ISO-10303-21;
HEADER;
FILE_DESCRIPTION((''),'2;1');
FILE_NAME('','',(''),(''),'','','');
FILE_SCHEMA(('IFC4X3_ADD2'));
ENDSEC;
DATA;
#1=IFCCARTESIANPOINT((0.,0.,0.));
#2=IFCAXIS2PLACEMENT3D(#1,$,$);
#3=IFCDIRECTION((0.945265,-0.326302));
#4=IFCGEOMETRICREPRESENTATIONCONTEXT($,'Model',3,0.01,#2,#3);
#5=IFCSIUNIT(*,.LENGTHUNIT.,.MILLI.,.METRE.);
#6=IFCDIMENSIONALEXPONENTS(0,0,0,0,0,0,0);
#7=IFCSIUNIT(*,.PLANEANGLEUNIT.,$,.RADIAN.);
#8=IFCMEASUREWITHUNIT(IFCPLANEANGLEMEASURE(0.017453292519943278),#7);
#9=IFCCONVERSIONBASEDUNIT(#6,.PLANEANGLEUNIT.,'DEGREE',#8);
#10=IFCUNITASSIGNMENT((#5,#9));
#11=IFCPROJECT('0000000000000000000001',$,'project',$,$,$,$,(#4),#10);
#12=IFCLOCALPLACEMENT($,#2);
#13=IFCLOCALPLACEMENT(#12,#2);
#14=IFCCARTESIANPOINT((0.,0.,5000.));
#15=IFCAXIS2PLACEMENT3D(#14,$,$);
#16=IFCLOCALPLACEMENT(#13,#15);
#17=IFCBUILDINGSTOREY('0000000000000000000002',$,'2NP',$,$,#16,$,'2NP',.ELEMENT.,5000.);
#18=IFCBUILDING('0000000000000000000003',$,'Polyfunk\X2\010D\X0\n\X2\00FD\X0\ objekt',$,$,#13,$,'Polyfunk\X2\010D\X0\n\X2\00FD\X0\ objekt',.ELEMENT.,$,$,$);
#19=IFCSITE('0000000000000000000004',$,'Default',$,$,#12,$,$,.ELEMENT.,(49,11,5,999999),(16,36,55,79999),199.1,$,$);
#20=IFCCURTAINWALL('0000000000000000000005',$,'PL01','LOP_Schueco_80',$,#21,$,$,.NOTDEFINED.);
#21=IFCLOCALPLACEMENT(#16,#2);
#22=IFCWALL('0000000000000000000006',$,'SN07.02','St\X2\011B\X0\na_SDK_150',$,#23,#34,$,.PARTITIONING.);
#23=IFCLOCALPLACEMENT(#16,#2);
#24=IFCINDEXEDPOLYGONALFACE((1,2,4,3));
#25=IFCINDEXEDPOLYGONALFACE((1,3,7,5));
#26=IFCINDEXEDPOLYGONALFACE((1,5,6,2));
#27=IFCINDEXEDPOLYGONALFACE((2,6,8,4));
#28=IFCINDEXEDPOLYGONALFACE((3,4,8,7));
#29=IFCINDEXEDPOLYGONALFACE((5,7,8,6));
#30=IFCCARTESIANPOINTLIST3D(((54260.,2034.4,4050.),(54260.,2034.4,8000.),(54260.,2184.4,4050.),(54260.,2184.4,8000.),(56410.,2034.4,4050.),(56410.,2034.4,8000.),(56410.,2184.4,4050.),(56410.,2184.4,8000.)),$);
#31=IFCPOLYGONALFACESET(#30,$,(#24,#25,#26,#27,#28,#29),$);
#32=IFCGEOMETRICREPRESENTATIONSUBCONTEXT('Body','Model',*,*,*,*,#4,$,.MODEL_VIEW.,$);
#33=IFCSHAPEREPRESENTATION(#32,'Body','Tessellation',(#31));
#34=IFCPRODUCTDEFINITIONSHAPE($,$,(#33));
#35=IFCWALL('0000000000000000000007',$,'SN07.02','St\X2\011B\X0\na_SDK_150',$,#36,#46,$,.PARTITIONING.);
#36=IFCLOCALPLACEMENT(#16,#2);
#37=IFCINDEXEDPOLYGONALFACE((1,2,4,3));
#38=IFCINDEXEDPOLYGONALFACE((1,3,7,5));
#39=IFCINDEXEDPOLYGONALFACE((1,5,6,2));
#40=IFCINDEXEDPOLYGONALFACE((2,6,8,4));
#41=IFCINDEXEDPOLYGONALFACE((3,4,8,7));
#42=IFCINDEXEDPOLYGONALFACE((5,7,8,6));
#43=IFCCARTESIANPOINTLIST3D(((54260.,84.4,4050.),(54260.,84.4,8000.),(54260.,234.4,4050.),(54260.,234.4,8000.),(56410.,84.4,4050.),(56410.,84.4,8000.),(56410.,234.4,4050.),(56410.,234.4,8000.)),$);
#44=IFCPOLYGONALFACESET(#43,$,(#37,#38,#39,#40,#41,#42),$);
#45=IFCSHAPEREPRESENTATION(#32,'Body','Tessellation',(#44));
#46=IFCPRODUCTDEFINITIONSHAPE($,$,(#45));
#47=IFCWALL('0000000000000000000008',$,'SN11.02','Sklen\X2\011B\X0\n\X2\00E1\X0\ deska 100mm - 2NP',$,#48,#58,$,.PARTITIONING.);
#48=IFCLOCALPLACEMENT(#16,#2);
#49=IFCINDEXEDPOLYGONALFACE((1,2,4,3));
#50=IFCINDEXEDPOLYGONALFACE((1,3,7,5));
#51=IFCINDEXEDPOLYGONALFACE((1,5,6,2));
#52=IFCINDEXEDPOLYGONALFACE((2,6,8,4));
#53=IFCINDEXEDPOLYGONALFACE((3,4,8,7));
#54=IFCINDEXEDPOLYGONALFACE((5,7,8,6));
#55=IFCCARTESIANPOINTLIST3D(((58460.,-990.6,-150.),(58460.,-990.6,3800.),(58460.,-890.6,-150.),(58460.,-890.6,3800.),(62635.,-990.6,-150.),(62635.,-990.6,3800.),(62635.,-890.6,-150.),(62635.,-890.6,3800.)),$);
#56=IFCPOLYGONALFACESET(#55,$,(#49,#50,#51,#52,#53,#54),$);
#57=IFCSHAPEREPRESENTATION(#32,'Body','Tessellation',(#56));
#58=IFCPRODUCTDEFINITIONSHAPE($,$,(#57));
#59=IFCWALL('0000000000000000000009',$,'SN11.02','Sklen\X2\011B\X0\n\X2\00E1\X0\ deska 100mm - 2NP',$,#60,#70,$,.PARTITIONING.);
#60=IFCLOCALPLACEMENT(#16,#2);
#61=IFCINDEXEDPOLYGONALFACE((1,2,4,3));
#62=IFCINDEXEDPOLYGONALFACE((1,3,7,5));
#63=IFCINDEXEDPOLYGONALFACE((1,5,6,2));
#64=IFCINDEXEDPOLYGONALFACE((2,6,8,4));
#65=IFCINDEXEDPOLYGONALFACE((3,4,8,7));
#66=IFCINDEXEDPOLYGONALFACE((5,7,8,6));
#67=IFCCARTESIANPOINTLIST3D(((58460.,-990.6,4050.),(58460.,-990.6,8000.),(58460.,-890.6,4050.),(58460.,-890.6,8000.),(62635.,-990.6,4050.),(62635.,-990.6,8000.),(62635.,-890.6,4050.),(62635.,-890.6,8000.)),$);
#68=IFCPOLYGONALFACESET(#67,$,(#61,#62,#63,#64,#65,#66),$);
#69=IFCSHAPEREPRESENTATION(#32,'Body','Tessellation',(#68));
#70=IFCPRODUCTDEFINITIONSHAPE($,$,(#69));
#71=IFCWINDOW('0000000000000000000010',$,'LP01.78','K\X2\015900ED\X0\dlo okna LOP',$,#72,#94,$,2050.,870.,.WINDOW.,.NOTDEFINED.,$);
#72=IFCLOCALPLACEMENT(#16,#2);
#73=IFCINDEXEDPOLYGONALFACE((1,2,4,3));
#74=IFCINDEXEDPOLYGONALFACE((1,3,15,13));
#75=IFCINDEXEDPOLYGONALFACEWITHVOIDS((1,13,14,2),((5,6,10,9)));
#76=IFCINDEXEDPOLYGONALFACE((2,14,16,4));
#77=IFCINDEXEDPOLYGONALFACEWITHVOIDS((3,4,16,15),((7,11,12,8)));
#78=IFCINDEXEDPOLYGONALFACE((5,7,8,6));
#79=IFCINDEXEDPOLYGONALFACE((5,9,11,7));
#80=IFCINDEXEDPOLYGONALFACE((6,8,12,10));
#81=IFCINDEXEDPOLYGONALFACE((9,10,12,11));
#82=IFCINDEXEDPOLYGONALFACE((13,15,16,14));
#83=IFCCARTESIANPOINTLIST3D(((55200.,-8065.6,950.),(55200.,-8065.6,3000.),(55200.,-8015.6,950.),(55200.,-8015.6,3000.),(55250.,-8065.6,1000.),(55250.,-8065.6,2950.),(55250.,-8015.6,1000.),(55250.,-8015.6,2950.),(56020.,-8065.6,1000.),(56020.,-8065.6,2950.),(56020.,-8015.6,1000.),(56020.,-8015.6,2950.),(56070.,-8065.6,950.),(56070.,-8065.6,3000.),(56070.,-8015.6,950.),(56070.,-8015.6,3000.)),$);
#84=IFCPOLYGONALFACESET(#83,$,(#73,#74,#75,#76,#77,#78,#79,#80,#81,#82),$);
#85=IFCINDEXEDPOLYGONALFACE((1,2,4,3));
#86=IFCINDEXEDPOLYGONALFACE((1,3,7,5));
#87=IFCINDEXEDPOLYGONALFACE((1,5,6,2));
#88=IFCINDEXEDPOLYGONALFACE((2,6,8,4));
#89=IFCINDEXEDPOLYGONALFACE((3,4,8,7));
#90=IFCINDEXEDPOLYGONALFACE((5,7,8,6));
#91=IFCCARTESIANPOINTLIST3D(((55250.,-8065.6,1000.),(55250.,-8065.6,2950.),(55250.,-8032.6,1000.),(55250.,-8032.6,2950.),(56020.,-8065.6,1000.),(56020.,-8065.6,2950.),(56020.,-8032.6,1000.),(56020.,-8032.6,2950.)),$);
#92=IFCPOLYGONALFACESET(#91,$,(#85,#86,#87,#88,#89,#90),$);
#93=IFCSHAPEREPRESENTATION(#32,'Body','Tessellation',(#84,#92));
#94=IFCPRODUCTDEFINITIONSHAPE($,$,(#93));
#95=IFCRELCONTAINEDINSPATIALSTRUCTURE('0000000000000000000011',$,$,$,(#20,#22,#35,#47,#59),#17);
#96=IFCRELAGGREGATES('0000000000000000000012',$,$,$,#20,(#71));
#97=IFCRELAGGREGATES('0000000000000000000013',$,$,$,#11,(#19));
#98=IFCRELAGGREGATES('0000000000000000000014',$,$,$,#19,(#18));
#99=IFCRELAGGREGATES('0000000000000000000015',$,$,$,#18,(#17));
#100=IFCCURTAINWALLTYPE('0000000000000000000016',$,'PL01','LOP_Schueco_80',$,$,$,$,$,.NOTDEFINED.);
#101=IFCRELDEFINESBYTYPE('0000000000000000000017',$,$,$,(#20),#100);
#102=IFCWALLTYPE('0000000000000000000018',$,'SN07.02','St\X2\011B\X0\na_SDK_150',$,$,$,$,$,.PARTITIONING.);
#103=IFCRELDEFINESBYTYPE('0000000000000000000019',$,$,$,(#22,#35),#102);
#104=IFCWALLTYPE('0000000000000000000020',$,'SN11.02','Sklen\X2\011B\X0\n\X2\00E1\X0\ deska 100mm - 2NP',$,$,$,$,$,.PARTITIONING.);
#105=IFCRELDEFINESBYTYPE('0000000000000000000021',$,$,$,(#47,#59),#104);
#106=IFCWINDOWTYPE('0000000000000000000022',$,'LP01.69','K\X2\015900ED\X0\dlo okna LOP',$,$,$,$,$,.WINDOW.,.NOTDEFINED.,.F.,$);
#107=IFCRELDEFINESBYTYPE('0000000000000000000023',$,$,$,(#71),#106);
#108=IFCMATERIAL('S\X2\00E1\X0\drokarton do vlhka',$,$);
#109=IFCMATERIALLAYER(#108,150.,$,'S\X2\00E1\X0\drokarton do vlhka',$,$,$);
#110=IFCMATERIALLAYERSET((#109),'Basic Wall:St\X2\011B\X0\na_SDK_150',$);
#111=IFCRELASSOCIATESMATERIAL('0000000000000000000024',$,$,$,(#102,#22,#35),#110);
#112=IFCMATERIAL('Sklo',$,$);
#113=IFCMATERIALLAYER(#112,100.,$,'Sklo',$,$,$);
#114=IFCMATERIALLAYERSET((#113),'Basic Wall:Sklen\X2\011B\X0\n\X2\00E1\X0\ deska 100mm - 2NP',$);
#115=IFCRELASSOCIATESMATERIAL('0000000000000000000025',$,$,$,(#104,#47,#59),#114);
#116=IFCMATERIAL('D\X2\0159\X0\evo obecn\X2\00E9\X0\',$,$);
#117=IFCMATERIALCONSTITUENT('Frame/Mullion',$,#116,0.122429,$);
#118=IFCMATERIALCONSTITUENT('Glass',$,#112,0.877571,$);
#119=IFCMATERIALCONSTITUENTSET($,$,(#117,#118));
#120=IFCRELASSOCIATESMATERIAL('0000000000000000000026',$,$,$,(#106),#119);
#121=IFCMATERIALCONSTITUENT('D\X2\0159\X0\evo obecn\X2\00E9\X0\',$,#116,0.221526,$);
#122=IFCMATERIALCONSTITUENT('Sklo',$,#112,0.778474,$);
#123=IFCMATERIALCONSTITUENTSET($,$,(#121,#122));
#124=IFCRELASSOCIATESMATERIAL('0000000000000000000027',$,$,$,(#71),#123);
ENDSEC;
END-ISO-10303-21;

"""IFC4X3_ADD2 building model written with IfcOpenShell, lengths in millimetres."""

from ifc_helpers import new_model, entity, si_unit, converted_unit, direction, frame, frame_2d, origin, place, context, subcontext, project, spatial, polyline, rectangle, outline, extrude, clip, bounded_halfspace, source, transform, mapped, material, layer, layer_set, constituent, constituent_set, type_object, type_shapes, element, aggregate, save


model = new_model("IFC4X3_ADD2")

# Units and contexts
model_context = context("Model", 3, precision=0.01, world=origin(), true_north=direction((0.945265, -0.326302)))
body_context = subcontext(model_context, "Body", "Model", "MODEL_VIEW")
ifc_project = project(units=[si_unit("LENGTHUNIT", "METRE", prefix="MILLI"), converted_unit("PLANEANGLEUNIT", "DEGREE", entity("IfcPlaneAngleMeasure", 0.017453292519943278), si_unit("PLANEANGLEUNIT", "RADIAN"), dimensions=[0, 0, 0, 0, 0, 0, 0])], contexts=[model_context])

# Site, building, storey
site_placement = place(None, origin())
site = spatial("IfcSite", under=ifc_project, at=site_placement, Name="Default", CompositionType="ELEMENT", RefLatitude=(49, 11, 5, 999999), RefLongitude=(16, 36, 55, 79999), RefElevation=199.1)
building_placement = place(site_placement, origin())
building = spatial("IfcBuilding", under=site, at=building_placement, Name="Polyfunkčný objekt", LongName="Polyfunkčný objekt", CompositionType="ELEMENT")
storey_placement = place(building_placement, frame((0.0, 0.0, 5000.0)))
storey = spatial("IfcBuildingStorey", under=building, at=storey_placement, Name="2NP", LongName="2NP", CompositionType="ELEMENT", Elevation=5000.0)

# Curtain wall
curtain_wall_type = type_object("IfcCurtainWallType", Name="PL01", Description="LOP_Schueco_80", PredefinedType="NOTDEFINED")
curtain_wall_placement = place(storey_placement, frame((0.0, 0.0, -5000.0)))
curtain_wall = element("IfcCurtainWall", 1, at=curtain_wall_placement, inside=storey, type_object=curtain_wall_type, Name="PL01", Description="LOP_Schueco_80", PredefinedType="NOTDEFINED")
ifc_material_1 = material(Name="Sklo")

# Walls
ifc_material_2 = material(Name="Sádrokarton do vlhka")
ifc_layer_1 = layer(ifc_material_2, 150.0, Name="Sádrokarton do vlhka")
ifc_layer_set_1 = layer_set([ifc_layer_1], Name="Basic Wall:Stěna_SDK_150")
wall_type_1 = type_object("IfcWallType", Name="SN07.02", Description="Stěna_SDK_150", PredefinedType="PARTITIONING", material=ifc_layer_set_1)
wall_1_placement = place(storey_placement, frame((56410.0, 2109.4, 4050.0), z_axis=(0.0, 0.0, 1.0), x_axis=(-1.0, 0.0, 0.0)))
element("IfcWall", 2, at=wall_1_placement, inside=storey, type_object=wall_type_1, material=ifc_layer_set_1, Name="SN07.02", Description="Stěna_SDK_150", PredefinedType="PARTITIONING", context=body_context, shape_type="Clipping", body=[
    clip(clip(extrude(rectangle(XDim=2150.0, YDim=150.0, at=frame_2d((1075.0, 0.0), x_axis=(-1.0, 0.0))), origin(), (0.0, 0.0, 1.0), 3950.0), bounded_halfspace(frame((2150.0, -75.0, 0.0)), True, frame((2150.0, -75.0, 0.0)), polyline([(0.0, 0.0), (0.0, 150.0), (-2150.0, 150.0), (-2150.0, 0.0), (0.0, 0.0)]))), bounded_halfspace(frame((0.0, -75.0, 3950.0), z_axis=(0.0, 0.0, -1.0), x_axis=(-1.0, 0.0, 0.0)), True, frame((0.0, -75.0, 3950.0)), polyline([(0.0, 0.0), (2150.0, 0.0), (2150.0, 150.0), (0.0, 150.0), (0.0, 0.0)]))),
])
wall_2_placement = place(storey_placement, frame((56410.0, 159.4, 4050.0), z_axis=(0.0, 0.0, 1.0), x_axis=(-1.0, 0.0, 0.0)))
element("IfcWall", 3, at=wall_2_placement, inside=storey, type_object=wall_type_1, material=ifc_layer_set_1, Name="SN07.02", Description="Stěna_SDK_150", PredefinedType="PARTITIONING", context=body_context, shape_type="Clipping", body=[
    clip(clip(extrude(rectangle(XDim=2150.0, YDim=150.0, at=frame_2d((1075.0, 0.0), x_axis=(-1.0, 0.0))), origin(), (0.0, 0.0, 1.0), 3950.0), bounded_halfspace(frame((2150.0, -75.0, 0.0)), True, frame((2150.0, -75.0, 0.0)), polyline([(0.0, 0.0), (0.0, 150.0), (-2150.0, 150.0), (-2150.0, 0.0), (0.0, 0.0)]))), bounded_halfspace(frame((0.0, -75.0, 3950.0), z_axis=(0.0, 0.0, -1.0), x_axis=(-1.0, 0.0, 0.0)), True, frame((0.0, -75.0, 3950.0)), polyline([(0.0, 0.0), (2150.0, 0.0), (2150.0, 150.0), (0.0, 150.0), (0.0, 0.0)]))),
])
ifc_layer_2 = layer(ifc_material_1, 100.0, Name="Sklo")
ifc_layer_set_2 = layer_set([ifc_layer_2], Name="Basic Wall:Skleněná deska 100mm - 2NP")
wall_type_2 = type_object("IfcWallType", Name="SN11.02", Description="Skleněná deska 100mm - 2NP", PredefinedType="PARTITIONING", material=ifc_layer_set_2)
wall_3_placement = place(storey_placement, frame((58460.0, -940.6, -150.0)))
element("IfcWall", 4, at=wall_3_placement, inside=storey, type_object=wall_type_2, material=ifc_layer_set_2, Name="SN11.02", Description="Skleněná deska 100mm - 2NP", PredefinedType="PARTITIONING", context=body_context, shape_type="Clipping", body=[
    clip(clip(extrude(rectangle(XDim=4175.0, YDim=100.0, at=frame_2d((2087.5, 0.0), x_axis=(-1.0, 0.0))), origin(), (0.0, 0.0, 1.0), 3950.0), bounded_halfspace(frame((4175.0, -50.0, 0.0), z_axis=(0.0, 0.0, 1.0), x_axis=(-1.0, 0.0, 0.0)), True, frame((4175.0, -50.0, 0.0)), polyline([(0.0, 0.0), (0.0, 100.0), (-4075.0, 100.0), (-4175.0, 100.0), (-4175.0, 0.0), (0.0, 0.0)]))), bounded_halfspace(frame((0.0, -50.0, 3950.0), z_axis=(0.0, 0.0, -1.0), x_axis=(1.0, 0.0, 0.0)), True, frame((0.0, -50.0, 3950.0)), polyline([(0.0, 0.0), (4175.0, 0.0), (4175.0, 100.0), (100.0, 100.0), (0.0, 100.0), (0.0, 0.0)]))),
])
wall_4_placement = place(storey_placement, frame((58460.0, -940.6, 4050.0)))
element("IfcWall", 5, at=wall_4_placement, inside=storey, type_object=wall_type_2, material=ifc_layer_set_2, Name="SN11.02", Description="Skleněná deska 100mm - 2NP", PredefinedType="PARTITIONING", context=body_context, shape_type="Clipping", body=[
    clip(clip(extrude(rectangle(XDim=4175.0, YDim=100.0, at=frame_2d((2087.5, 0.0), x_axis=(-1.0, 0.0))), origin(), (0.0, 0.0, 1.0), 3950.0), bounded_halfspace(frame((4175.0, -50.0, 0.0), z_axis=(0.0, 0.0, 1.0), x_axis=(-1.0, 0.0, 0.0)), True, frame((4175.0, -50.0, 0.0)), polyline([(0.0, 0.0), (0.0, 100.0), (-4075.0, 100.0), (-4175.0, 100.0), (-4175.0, 0.0), (0.0, 0.0)]))), bounded_halfspace(frame((0.0, -50.0, 3950.0), z_axis=(0.0, 0.0, -1.0), x_axis=(1.0, 0.0, 0.0)), True, frame((0.0, -50.0, 3950.0)), polyline([(0.0, 0.0), (4175.0, 0.0), (4175.0, 100.0), (100.0, 100.0), (0.0, 100.0), (0.0, 0.0)]))),
])

# Window
ifc_material_3 = material(Name="Dřevo obecné")
ifc_constituent_1 = constituent(ifc_material_3, Name="Dřevo obecné", fraction=0.221526)
ifc_constituent_2 = constituent(ifc_material_1, Name="Sklo", fraction=0.778474)
ifc_constituent_set_1 = constituent_set(constituents=[ifc_constituent_1, ifc_constituent_2])
ifc_constituent_3 = constituent(ifc_material_3, Name="Frame/Mullion", fraction=0.122429)
ifc_constituent_4 = constituent(ifc_material_1, Name="Glass", fraction=0.877571)
ifc_constituent_set_2 = constituent_set(constituents=[ifc_constituent_3, ifc_constituent_4])
window_type = type_object("IfcWindowType", Name="LP01.69", Description="Křídlo okna LOP", ParameterTakesPrecedence=False, PartitioningType="NOTDEFINED", PredefinedType="WINDOW", material=ifc_constituent_set_2)
shared_shape_1 = source(origin(), body_context, "Body", "SweptSolid", [
    extrude(outline(polyline([(-1025.0, -435.0), (1025.0, -435.0), (1025.0, 435.0), (-1025.0, 435.0), (-1025.0, -435.0)]), holes=[polyline([(-975.0, -385.0), (-975.0, 385.0), (975.0, 385.0), (975.0, -385.0), (-975.0, -385.0)])]), frame((0.0, 50.0, 1025.0), z_axis=(0.0, -1.0, 0.0), x_axis=(0.0, 0.0, -1.0)), (0.0, 0.0, 1.0), 50.0),
    extrude(rectangle(XDim=770.0, YDim=33.0, at=frame_2d((0.0, 0.0), x_axis=(1.0, 0.0))), frame((0.0, 33.5, 50.0), z_axis=(0.0, 0.0, 1.0), x_axis=(-1.0, 0.0, 0.0)), (0.0, 0.0, 1.0), 1950.0),
])
type_shapes(window_type, [shared_shape_1])
window_placement = place(curtain_wall_placement, frame((55635.0, -8015.6, 5950.0), z_axis=(0.0, 0.0, 1.0), x_axis=(-1.0, 0.0, 0.0)))
window = element("IfcWindow", 6, at=window_placement, type_object=window_type, material=ifc_constituent_set_1, Name="LP01.78", Description="Křídlo okna LOP", OverallHeight=2050.0, OverallWidth=870.0, PartitioningType="NOTDEFINED", PredefinedType="WINDOW", context=body_context, shape_type="MappedRepresentation", body=[
    mapped(shared_shape_1, transform((0.0, 0.0, 0.0), scale=1.0)),
])
aggregate(curtain_wall, [window])

save(model, "model.ifc")
